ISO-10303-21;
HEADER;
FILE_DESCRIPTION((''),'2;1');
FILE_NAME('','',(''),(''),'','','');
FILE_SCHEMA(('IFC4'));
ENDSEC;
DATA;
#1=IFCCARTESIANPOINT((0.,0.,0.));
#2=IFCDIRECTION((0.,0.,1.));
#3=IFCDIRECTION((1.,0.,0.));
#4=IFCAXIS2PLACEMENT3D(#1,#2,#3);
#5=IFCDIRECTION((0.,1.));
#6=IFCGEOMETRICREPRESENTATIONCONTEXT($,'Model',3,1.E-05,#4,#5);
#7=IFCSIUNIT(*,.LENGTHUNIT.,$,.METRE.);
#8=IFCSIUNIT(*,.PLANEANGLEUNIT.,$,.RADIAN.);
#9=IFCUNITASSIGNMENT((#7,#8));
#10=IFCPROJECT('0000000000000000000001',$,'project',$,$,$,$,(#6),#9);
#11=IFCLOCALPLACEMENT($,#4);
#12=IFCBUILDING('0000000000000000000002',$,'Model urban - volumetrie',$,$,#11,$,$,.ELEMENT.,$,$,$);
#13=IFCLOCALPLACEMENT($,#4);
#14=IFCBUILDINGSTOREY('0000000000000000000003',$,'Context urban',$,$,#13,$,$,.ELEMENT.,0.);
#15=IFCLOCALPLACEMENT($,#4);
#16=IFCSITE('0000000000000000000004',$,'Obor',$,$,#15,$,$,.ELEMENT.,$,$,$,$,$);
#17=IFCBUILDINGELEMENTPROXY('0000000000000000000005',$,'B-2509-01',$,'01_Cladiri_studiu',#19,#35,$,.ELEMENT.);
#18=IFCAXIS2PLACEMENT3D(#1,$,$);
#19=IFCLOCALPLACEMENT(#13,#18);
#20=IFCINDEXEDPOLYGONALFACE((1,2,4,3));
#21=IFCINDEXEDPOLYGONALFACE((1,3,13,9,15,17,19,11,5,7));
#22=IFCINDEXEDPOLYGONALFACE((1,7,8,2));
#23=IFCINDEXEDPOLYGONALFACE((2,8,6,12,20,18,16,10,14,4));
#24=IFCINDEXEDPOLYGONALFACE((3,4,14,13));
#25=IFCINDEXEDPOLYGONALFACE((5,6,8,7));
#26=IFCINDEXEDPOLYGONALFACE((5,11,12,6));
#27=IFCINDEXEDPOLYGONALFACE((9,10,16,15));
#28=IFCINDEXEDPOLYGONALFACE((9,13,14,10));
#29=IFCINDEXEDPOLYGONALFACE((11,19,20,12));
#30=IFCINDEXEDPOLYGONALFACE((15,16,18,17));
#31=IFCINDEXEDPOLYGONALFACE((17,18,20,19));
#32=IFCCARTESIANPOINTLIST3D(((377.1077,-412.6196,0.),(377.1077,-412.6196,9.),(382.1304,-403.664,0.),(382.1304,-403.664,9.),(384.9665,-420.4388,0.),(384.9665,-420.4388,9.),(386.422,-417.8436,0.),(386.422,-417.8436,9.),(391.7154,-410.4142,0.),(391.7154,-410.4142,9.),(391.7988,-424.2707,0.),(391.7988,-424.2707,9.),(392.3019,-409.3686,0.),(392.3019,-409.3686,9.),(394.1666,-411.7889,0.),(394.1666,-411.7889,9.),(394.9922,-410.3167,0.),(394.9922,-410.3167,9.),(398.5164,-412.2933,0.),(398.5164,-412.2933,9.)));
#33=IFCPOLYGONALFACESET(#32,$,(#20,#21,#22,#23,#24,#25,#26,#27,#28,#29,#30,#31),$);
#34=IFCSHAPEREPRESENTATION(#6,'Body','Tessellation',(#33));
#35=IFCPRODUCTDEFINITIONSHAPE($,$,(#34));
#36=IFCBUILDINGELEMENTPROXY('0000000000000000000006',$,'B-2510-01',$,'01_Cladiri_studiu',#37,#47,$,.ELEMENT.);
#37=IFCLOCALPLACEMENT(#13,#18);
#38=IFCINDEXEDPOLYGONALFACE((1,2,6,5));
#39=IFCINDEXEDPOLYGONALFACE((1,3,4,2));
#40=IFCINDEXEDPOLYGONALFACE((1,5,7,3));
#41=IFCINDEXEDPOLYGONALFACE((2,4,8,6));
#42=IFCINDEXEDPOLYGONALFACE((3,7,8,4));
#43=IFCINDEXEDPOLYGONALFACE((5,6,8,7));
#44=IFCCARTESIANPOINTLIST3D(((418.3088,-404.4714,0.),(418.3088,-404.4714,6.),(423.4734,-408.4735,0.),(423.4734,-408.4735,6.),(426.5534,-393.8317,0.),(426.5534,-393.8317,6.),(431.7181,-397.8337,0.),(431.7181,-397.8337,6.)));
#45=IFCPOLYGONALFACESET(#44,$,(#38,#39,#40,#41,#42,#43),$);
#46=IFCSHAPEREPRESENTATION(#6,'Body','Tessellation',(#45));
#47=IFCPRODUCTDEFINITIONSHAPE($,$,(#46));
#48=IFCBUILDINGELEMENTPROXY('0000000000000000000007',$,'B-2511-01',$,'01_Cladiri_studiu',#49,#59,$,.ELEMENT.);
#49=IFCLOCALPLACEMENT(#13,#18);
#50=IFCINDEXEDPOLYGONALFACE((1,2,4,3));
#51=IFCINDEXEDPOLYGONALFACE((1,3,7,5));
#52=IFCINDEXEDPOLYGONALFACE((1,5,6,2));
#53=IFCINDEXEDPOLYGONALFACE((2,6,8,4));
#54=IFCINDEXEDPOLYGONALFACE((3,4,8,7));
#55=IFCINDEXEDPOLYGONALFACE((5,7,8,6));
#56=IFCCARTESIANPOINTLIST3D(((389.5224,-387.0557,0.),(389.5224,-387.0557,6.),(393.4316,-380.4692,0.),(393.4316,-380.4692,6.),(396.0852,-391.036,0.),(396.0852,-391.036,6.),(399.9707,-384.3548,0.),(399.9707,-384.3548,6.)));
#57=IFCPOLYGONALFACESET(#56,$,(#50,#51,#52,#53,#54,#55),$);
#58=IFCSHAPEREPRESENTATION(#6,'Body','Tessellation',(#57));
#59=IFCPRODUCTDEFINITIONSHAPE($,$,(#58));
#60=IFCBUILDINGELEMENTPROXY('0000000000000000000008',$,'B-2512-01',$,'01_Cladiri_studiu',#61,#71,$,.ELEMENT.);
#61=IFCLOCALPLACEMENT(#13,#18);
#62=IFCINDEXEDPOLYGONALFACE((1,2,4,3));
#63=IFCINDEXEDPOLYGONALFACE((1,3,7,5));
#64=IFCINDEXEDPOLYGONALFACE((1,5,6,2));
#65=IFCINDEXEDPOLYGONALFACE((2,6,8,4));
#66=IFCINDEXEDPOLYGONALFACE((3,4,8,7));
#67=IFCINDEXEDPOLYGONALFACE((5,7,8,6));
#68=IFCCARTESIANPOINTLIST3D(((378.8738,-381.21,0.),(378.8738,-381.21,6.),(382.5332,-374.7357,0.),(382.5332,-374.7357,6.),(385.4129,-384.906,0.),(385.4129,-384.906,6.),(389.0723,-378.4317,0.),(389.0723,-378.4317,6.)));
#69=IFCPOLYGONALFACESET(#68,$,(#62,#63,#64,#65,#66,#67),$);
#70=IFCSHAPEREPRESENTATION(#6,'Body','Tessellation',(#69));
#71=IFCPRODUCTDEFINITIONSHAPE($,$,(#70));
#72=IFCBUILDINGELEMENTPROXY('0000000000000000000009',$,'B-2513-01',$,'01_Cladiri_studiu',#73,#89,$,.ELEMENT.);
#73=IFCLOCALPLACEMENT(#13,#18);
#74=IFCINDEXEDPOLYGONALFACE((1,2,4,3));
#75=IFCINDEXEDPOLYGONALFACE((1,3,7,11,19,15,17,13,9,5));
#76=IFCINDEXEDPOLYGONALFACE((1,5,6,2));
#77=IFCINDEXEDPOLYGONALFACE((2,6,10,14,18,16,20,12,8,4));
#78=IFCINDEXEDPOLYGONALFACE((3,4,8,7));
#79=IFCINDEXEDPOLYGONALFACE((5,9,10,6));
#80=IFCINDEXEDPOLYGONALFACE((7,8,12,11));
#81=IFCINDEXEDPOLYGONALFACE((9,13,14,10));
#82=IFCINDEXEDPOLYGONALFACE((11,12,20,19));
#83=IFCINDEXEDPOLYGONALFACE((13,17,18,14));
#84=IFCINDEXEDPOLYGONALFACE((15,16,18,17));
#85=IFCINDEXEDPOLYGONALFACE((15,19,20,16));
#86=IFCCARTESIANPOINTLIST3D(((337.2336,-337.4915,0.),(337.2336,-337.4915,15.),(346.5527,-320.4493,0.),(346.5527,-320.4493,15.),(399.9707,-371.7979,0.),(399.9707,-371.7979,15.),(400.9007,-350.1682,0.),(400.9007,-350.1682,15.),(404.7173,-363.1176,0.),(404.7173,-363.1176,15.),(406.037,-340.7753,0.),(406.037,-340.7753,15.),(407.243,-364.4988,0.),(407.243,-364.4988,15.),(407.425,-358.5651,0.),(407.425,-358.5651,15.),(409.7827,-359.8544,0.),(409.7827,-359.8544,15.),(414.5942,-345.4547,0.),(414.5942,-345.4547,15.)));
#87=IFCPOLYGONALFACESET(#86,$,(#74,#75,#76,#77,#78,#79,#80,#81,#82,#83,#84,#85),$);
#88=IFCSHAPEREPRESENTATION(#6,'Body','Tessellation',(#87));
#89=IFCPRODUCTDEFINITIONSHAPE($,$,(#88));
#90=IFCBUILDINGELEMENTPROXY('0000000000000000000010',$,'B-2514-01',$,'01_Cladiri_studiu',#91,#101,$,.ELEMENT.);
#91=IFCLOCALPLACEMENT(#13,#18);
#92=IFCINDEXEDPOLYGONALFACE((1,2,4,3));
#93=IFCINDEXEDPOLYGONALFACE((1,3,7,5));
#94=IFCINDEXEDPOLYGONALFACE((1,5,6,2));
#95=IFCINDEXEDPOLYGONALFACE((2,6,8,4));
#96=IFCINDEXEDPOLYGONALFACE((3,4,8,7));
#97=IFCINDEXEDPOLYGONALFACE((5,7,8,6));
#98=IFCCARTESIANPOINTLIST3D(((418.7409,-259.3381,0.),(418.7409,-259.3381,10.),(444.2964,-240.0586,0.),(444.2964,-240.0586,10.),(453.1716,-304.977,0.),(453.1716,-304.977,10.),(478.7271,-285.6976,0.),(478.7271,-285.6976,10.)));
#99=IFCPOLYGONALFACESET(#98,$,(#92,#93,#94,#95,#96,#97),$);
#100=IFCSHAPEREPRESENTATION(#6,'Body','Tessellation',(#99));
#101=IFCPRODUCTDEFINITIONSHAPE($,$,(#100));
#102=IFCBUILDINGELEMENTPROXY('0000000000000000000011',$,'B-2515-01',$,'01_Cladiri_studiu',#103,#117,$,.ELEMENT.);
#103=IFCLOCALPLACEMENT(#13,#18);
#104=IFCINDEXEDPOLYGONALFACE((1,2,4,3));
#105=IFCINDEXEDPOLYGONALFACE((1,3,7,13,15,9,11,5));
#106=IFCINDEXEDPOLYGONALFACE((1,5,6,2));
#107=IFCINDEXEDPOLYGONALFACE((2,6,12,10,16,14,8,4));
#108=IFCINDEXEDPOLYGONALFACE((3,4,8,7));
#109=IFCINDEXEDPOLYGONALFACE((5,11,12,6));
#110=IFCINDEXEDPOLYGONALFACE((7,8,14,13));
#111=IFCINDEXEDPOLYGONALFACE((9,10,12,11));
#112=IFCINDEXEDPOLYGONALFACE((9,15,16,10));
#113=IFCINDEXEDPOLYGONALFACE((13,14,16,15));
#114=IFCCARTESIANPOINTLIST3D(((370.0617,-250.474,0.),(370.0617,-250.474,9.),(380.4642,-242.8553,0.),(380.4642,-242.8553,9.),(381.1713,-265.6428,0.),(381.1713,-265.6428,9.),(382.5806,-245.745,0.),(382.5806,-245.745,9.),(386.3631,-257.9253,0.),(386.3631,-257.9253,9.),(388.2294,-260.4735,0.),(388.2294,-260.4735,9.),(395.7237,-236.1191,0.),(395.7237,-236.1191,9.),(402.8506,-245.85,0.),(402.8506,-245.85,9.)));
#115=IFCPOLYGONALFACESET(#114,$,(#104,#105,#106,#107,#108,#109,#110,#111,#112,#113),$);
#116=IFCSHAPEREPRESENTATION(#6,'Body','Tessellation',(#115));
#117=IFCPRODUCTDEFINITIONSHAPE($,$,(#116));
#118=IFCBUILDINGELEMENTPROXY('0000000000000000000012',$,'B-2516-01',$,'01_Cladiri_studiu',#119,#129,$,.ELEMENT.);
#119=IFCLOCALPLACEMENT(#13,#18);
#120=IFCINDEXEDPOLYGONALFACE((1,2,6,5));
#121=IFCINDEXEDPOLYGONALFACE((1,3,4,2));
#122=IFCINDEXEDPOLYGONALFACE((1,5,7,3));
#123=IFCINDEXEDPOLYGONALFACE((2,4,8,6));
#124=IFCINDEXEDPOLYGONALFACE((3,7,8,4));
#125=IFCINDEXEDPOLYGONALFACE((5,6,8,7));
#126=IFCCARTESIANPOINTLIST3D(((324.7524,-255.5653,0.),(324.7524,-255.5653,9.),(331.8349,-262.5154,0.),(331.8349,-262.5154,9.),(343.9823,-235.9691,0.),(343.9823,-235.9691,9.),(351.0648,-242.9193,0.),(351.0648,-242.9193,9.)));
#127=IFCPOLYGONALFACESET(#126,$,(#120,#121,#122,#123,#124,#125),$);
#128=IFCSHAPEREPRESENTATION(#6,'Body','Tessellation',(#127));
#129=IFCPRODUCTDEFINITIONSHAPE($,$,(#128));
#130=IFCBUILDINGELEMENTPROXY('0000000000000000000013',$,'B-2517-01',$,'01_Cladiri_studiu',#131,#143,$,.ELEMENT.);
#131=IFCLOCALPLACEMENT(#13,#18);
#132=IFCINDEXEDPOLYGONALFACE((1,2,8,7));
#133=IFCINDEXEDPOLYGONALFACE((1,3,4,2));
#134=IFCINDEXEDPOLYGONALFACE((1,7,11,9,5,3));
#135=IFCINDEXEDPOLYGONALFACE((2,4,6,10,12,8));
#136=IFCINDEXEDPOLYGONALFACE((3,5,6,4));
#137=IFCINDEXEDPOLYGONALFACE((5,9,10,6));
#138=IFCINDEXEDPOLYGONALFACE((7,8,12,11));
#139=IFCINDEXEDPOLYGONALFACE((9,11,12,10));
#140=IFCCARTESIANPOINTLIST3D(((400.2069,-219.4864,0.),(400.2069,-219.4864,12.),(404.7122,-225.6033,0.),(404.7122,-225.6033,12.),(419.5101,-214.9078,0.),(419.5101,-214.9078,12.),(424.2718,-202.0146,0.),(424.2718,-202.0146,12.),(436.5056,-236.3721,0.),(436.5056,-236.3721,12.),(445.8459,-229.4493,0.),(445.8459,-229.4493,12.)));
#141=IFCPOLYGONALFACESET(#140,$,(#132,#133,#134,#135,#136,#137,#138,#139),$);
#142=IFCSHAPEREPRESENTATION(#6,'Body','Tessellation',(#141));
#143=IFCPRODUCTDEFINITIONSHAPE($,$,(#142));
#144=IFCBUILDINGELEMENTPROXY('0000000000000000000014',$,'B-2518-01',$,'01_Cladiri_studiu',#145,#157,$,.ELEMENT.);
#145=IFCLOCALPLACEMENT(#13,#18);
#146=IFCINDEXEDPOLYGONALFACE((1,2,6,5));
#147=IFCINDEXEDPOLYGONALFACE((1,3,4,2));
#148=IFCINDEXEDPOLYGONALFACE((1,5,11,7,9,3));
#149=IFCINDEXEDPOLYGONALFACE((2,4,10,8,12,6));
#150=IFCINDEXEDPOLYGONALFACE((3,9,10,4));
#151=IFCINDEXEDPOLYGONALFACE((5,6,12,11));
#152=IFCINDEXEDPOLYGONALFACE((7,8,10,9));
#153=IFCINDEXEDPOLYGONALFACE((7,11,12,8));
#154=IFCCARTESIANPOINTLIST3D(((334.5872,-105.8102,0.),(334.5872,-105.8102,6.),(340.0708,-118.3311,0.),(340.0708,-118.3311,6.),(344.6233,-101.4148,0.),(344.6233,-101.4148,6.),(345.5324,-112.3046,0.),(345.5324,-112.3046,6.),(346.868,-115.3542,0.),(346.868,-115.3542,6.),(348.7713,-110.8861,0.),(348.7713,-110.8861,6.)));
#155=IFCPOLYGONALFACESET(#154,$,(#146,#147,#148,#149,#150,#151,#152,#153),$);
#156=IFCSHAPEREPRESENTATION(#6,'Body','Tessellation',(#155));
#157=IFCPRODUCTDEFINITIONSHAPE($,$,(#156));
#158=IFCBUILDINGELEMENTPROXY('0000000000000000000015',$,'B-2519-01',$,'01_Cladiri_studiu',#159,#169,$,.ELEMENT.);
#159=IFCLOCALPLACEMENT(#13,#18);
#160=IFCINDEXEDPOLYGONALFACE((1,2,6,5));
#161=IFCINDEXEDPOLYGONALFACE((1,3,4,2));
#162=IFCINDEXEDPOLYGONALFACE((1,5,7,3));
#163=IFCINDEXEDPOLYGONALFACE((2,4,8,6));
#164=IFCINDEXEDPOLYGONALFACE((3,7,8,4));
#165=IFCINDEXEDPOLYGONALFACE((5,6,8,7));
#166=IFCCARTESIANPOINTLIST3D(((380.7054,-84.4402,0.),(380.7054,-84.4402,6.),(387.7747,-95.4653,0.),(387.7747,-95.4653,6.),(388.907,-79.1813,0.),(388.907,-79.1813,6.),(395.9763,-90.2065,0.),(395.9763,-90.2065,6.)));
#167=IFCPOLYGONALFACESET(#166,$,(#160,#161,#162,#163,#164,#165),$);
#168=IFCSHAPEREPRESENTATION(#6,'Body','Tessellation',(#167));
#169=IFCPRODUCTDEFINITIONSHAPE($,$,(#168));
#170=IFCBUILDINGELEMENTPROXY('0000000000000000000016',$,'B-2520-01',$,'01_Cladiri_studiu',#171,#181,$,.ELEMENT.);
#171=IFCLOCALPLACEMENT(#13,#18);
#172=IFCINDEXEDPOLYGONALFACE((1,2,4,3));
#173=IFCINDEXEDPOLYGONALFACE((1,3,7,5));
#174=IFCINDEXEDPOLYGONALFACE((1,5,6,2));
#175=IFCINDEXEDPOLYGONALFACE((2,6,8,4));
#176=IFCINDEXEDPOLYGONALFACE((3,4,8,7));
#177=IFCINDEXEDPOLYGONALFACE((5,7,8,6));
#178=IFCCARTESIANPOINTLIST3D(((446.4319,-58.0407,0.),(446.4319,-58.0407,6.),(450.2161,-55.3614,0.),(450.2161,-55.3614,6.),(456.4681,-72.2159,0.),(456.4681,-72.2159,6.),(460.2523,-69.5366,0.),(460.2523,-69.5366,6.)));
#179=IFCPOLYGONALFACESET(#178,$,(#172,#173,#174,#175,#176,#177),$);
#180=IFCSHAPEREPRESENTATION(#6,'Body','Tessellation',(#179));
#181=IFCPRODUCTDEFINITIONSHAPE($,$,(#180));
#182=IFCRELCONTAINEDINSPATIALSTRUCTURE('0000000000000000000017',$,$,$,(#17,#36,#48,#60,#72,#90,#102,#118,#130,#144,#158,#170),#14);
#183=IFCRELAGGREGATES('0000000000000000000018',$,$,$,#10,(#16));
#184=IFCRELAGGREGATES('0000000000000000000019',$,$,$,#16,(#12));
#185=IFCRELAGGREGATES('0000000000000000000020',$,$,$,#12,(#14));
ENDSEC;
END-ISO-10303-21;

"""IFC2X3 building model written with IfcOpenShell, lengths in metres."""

from ifc_helpers import new_model, si_unit, direction, origin_with_axes, place, context, project, spatial, polyline, outline, extrude, element, save


model = new_model("IFC2X3")

# Units and contexts
model_context = context("Model", 3, precision=1e-05, world=origin_with_axes(), true_north=direction((0.0, 1.0)))
ifc_project = project(units=[si_unit("LENGTHUNIT", "METRE"), si_unit("PLANEANGLEUNIT", "RADIAN")], contexts=[model_context])

# Site, building, storey
site_placement = place(None, origin_with_axes())
site = spatial("IfcSite", under=ifc_project, at=site_placement, Name="Obor", CompositionType="ELEMENT")
building_placement = place(None, origin_with_axes())
building = spatial("IfcBuilding", under=site, at=building_placement, Name="Model urban - volumetrie", CompositionType="ELEMENT")
storey_placement = place(None, origin_with_axes())
storey = spatial("IfcBuildingStorey", under=building, at=storey_placement, Name="Context urban", CompositionType="ELEMENT", Elevation=0.0)

# Building element proxies
proxy_1_placement = place(None, origin_with_axes())
element("IfcBuildingElementProxy", 1, at=proxy_1_placement, inside=storey, Name="B-2509-01", ObjectType="01_Cladiri_studiu", CompositionType="ELEMENT", context=model_context, shape_type="SweptSolid", body=[
    extrude(outline(polyline([(398.5164, -412.2933), (394.9922, -410.3167), (394.1666, -411.7889), (391.7154, -410.4142), (392.3019, -409.3686), (382.1304, -403.664), (377.1077, -412.6196), (386.422, -417.8436), (384.9665, -420.4388), (391.7988, -424.2707), (398.5164, -412.2933)])), origin_with_axes(), (0.0, 0.0, 1.0), 9.0),
])
proxy_2_placement = place(None, origin_with_axes())
element("IfcBuildingElementProxy", 2, at=proxy_2_placement, inside=storey, Name="B-2510-01", ObjectType="01_Cladiri_studiu", CompositionType="ELEMENT", context=model_context, shape_type="SweptSolid", body=[
    extrude(outline(polyline([(431.7181, -397.8337), (426.5534, -393.8317), (418.3088, -404.4714), (423.4734, -408.4735), (431.7181, -397.8337)])), origin_with_axes(), (0.0, 0.0, 1.0), 6.0),
])
proxy_3_placement = place(None, origin_with_axes())
element("IfcBuildingElementProxy", 3, at=proxy_3_placement, inside=storey, Name="B-2511-01", ObjectType="01_Cladiri_studiu", CompositionType="ELEMENT", context=model_context, shape_type="SweptSolid", body=[
    extrude(outline(polyline([(396.0852, -391.036), (399.9707, -384.3548), (393.4316, -380.4692), (389.5224, -387.0557), (396.0852, -391.036)])), origin_with_axes(), (0.0, 0.0, 1.0), 6.0),
])
proxy_4_placement = place(None, origin_with_axes())
element("IfcBuildingElementProxy", 4, at=proxy_4_placement, inside=storey, Name="B-2512-01", ObjectType="01_Cladiri_studiu", CompositionType="ELEMENT", context=model_context, shape_type="SweptSolid", body=[
    extrude(outline(polyline([(385.4129, -384.906), (389.0723, -378.4317), (382.5332, -374.7357), (378.8738, -381.21), (385.4129, -384.906)])), origin_with_axes(), (0.0, 0.0, 1.0), 6.0),
])
proxy_5_placement = place(None, origin_with_axes())
element("IfcBuildingElementProxy", 5, at=proxy_5_placement, inside=storey, Name="B-2513-01", ObjectType="01_Cladiri_studiu", CompositionType="ELEMENT", context=model_context, shape_type="SweptSolid", body=[
    extrude(outline(polyline([(407.425, -358.5651), (414.5942, -345.4547), (406.037, -340.7753), (400.9007, -350.1682), (346.5527, -320.4493), (337.2336, -337.4915), (399.9707, -371.7979), (404.7173, -363.1176), (407.243, -364.4988), (409.7827, -359.8544), (407.425, -358.5651)])), origin_with_axes(), (0.0, 0.0, 1.0), 15.0),
])
proxy_6_placement = place(None, origin_with_axes())
element("IfcBuildingElementProxy", 6, at=proxy_6_placement, inside=storey, Name="B-2514-01", ObjectType="01_Cladiri_studiu", CompositionType="ELEMENT", context=model_context, shape_type="SweptSolid", body=[
    extrude(outline(polyline([(453.1716, -304.977), (478.7271, -285.6976), (444.2964, -240.0586), (418.7409, -259.3381), (453.1716, -304.977)])), origin_with_axes(), (0.0, 0.0, 1.0), 10.0),
])
proxy_7_placement = place(None, origin_with_axes())
element("IfcBuildingElementProxy", 7, at=proxy_7_placement, inside=storey, Name="B-2515-01", ObjectType="01_Cladiri_studiu", CompositionType="ELEMENT", context=model_context, shape_type="SweptSolid", body=[
    extrude(outline(polyline([(388.2294, -260.4735), (386.3631, -257.9253), (402.8506, -245.85), (395.7237, -236.1191), (382.5806, -245.745), (380.4642, -242.8553), (370.0617, -250.474), (381.1713, -265.6428), (388.2294, -260.4735)])), origin_with_axes(), (0.0, 0.0, 1.0), 9.0),
])
proxy_8_placement = place(None, origin_with_axes())
element("IfcBuildingElementProxy", 8, at=proxy_8_placement, inside=storey, Name="B-2516-01", ObjectType="01_Cladiri_studiu", CompositionType="ELEMENT", context=model_context, shape_type="SweptSolid", body=[
    extrude(outline(polyline([(351.0648, -242.9193), (343.9823, -235.9691), (324.7524, -255.5653), (331.8349, -262.5154), (351.0648, -242.9193)])), origin_with_axes(), (0.0, 0.0, 1.0), 9.0),
])
proxy_9_placement = place(None, origin_with_axes())
element("IfcBuildingElementProxy", 9, at=proxy_9_placement, inside=storey, Name="B-2517-01", ObjectType="01_Cladiri_studiu", CompositionType="ELEMENT", context=model_context, shape_type="SweptSolid", body=[
    extrude(outline(polyline([(445.8459, -229.4493), (424.2718, -202.0146), (400.2069, -219.4864), (404.7122, -225.6033), (419.5101, -214.9078), (436.5056, -236.3721), (445.8459, -229.4493)])), origin_with_axes(), (0.0, 0.0, 1.0), 12.0),
])
proxy_10_placement = place(None, origin_with_axes())
element("IfcBuildingElementProxy", 10, at=proxy_10_placement, inside=storey, Name="B-2518-01", ObjectType="01_Cladiri_studiu", CompositionType="ELEMENT", context=model_context, shape_type="SweptSolid", body=[
    extrude(outline(polyline([(345.5324, -112.3046), (348.7713, -110.8861), (344.6233, -101.4148), (334.5872, -105.8102), (340.0708, -118.3311), (346.868, -115.3542), (345.5324, -112.3046)])), origin_with_axes(), (0.0, 0.0, 1.0), 6.0),
])
proxy_11_placement = place(None, origin_with_axes())
element("IfcBuildingElementProxy", 11, at=proxy_11_placement, inside=storey, Name="B-2519-01", ObjectType="01_Cladiri_studiu", CompositionType="ELEMENT", context=model_context, shape_type="SweptSolid", body=[
    extrude(outline(polyline([(380.7054, -84.4402), (387.7747, -95.4653), (395.9763, -90.2065), (388.907, -79.1813), (380.7054, -84.4402)])), origin_with_axes(), (0.0, 0.0, 1.0), 6.0),
])
proxy_12_placement = place(None, origin_with_axes())
element("IfcBuildingElementProxy", 12, at=proxy_12_placement, inside=storey, Name="B-2520-01", ObjectType="01_Cladiri_studiu", CompositionType="ELEMENT", context=model_context, shape_type="SweptSolid", body=[
    extrude(outline(polyline([(456.4681, -72.2159), (460.2523, -69.5366), (450.2161, -55.3614), (446.4319, -58.0407), (456.4681, -72.2159)])), origin_with_axes(), (0.0, 0.0, 1.0), 6.0),
])

save(model, "model.ifc")
